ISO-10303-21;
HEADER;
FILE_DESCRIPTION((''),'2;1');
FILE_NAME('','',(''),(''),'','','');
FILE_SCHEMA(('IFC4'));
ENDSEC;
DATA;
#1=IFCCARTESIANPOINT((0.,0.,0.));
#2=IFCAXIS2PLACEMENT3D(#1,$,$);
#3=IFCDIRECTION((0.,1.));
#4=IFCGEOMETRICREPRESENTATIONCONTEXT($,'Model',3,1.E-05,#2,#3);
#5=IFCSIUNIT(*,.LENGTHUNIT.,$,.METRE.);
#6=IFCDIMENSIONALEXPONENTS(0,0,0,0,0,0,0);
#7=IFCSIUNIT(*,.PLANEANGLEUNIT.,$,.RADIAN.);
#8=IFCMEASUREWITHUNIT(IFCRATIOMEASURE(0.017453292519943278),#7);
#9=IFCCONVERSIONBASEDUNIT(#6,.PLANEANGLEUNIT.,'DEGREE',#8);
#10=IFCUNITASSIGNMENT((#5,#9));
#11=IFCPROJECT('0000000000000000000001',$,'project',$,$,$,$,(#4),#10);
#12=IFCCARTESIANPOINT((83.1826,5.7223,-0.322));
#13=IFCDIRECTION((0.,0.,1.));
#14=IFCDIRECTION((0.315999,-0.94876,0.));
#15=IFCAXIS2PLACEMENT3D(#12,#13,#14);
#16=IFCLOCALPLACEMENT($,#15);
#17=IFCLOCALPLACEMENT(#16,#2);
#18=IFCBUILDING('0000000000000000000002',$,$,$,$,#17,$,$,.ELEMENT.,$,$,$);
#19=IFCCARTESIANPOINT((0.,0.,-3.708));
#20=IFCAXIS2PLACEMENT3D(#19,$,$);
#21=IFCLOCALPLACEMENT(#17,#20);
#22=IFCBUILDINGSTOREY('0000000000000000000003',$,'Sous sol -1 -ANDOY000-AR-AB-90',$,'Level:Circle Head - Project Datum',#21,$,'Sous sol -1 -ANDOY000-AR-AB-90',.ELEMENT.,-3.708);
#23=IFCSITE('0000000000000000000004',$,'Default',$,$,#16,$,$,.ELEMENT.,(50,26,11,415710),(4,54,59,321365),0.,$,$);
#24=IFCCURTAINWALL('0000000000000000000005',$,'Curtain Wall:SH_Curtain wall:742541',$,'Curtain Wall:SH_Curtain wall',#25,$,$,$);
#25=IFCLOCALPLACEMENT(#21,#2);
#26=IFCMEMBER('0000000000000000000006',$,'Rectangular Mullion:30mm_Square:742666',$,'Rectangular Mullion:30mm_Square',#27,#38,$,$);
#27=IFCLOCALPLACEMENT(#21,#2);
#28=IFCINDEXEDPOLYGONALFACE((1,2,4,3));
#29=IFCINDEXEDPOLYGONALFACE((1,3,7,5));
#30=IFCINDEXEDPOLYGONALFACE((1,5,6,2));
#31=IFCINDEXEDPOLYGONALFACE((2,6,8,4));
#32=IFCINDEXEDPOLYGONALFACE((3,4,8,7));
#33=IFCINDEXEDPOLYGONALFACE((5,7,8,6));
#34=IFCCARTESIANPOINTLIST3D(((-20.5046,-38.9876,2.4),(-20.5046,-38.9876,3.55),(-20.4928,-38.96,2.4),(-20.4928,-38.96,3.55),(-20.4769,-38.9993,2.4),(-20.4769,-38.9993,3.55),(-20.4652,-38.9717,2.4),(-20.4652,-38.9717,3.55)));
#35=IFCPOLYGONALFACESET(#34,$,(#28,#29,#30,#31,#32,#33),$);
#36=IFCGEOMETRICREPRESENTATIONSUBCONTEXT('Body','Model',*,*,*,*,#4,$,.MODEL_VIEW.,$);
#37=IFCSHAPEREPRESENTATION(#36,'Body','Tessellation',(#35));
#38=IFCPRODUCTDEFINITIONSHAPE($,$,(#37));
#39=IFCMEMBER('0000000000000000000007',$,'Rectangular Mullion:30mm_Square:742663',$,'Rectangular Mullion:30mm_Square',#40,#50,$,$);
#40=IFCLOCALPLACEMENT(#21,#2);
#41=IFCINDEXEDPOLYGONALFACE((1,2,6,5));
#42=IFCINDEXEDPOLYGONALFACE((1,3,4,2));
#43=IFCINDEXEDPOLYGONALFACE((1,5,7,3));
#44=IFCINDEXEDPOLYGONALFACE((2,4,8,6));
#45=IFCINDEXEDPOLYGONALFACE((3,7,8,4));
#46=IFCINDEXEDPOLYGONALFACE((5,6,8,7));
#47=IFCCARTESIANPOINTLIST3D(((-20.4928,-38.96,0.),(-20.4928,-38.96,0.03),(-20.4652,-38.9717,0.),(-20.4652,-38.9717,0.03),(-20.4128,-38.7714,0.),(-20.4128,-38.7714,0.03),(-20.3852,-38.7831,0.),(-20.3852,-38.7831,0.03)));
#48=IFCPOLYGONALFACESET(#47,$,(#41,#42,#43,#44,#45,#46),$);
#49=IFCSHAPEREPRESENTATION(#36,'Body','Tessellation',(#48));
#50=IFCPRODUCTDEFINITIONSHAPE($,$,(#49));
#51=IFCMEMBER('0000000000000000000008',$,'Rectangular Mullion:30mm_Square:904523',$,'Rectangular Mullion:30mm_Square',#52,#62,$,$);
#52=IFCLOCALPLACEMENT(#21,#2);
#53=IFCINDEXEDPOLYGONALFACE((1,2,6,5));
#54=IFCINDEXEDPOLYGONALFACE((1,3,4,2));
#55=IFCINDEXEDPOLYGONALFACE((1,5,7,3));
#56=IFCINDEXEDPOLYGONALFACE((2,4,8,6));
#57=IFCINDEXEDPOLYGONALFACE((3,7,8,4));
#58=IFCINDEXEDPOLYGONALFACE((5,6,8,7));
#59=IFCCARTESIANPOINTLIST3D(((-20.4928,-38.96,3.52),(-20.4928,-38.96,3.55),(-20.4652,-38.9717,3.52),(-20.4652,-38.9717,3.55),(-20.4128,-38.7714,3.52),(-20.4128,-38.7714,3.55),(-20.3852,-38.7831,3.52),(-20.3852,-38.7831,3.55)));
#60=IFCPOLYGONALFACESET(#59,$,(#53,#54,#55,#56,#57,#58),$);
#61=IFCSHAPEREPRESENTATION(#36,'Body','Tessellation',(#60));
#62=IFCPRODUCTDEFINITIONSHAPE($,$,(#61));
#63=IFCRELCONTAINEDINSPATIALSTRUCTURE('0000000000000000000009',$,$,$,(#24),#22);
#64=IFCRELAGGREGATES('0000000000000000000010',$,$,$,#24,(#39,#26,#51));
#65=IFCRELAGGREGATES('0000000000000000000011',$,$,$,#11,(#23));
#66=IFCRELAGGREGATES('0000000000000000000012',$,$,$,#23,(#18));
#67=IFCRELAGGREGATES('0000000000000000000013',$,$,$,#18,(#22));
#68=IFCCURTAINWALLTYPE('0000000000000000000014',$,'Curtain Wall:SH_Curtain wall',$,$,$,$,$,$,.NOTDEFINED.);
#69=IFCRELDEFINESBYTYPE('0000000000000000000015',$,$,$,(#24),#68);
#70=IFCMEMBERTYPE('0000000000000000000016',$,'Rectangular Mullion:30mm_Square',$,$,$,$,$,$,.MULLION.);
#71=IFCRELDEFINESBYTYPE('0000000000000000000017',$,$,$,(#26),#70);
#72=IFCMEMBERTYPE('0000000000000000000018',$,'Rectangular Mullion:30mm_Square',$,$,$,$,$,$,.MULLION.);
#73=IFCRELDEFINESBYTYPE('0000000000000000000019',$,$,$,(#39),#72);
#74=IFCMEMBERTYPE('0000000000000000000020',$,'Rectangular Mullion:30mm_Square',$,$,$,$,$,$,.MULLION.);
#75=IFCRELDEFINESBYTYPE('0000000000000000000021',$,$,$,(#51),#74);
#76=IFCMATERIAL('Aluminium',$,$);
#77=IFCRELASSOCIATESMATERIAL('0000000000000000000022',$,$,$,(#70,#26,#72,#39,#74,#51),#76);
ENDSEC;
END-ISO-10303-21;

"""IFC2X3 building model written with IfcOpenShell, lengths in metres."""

from ifc_helpers import new_model, entity, si_unit, converted_unit, direction, frame, origin, origin_2d_with_axis, place, context, subcontext, project, spatial, rectangle, extrude, source, transform, mapped, material, type_object, type_shapes, element, aggregate, save


model = new_model("IFC2X3")

# Units and contexts
model_context = context("Model", 3, precision=1e-05, world=origin(), true_north=direction((0.0, 1.0)))
body_context = subcontext(model_context, "Body", "Model", "MODEL_VIEW")
ifc_project = project(units=[si_unit("LENGTHUNIT", "METRE"), converted_unit("PLANEANGLEUNIT", "DEGREE", entity("IfcRatioMeasure", 0.017453292519943278), si_unit("PLANEANGLEUNIT", "RADIAN"), dimensions=[0, 0, 0, 0, 0, 0, 0])], contexts=[model_context])

# Site, building, storey
site_placement = place(None, frame((83.1826, 5.7223, -0.322), z_axis=(0.0, 0.0, 1.0), x_axis=(0.315999, -0.94876, 0.0)))
site = spatial("IfcSite", under=ifc_project, at=site_placement, Name="Default", CompositionType="ELEMENT", RefLatitude=(50, 26, 11, 415710), RefLongitude=(4, 54, 59, 321365), RefElevation=0.0)
building_placement = place(site_placement, origin())
building = spatial("IfcBuilding", under=site, at=building_placement, CompositionType="ELEMENT")
storey_placement = place(building_placement, frame((0.0, 0.0, -3.708)))
storey = spatial("IfcBuildingStorey", under=building, at=storey_placement, Name="Sous sol -1 -ANDOY000-AR-AB-90", ObjectType="Level:Circle Head - Project Datum", LongName="Sous sol -1 -ANDOY000-AR-AB-90", CompositionType="ELEMENT", Elevation=-3.708)

# Curtain wall, members
curtain_wall_type = type_object("IfcCurtainWallType", Name="Curtain Wall:SH_Curtain wall", PredefinedType="NOTDEFINED")
curtain_wall_placement = place(storey_placement, frame((0.0, 0.0, 3.708)))
curtain_wall = element("IfcCurtainWall", 1, at=curtain_wall_placement, inside=storey, type_object=curtain_wall_type, Name="Curtain Wall:SH_Curtain wall:742541", ObjectType="Curtain Wall:SH_Curtain wall")
ifc_material_1 = material(Name="Aluminium")
member_type_1 = type_object("IfcMemberType", Name="Rectangular Mullion:30mm_Square", PredefinedType="MULLION", material=ifc_material_1)
shared_shape_1 = source(origin(), body_context, "Body", "SweptSolid", [
    extrude(rectangle(XDim=0.03, YDim=0.03, at=origin_2d_with_axis()), frame((0.0, 0.0, -1.15), z_axis=(0.0, 0.0, 1.0), x_axis=(0.0, -1.0, 0.0)), (0.0, 0.0, 1.0), 1.15),
])
type_shapes(member_type_1, [shared_shape_1])
member_1_placement = place(curtain_wall_placement, frame((-20.4849, -38.9796, -1.308), z_axis=(0.0, 0.0, -1.0), x_axis=(0.390731, 0.920505, 0.0)))
member_1 = element("IfcMember", 2, at=member_1_placement, type_object=member_type_1, material=ifc_material_1, Name="Rectangular Mullion:30mm_Square:742666", ObjectType="Rectangular Mullion:30mm_Square", context=body_context, shape_type="MappedRepresentation", body=[
    mapped(shared_shape_1, transform((0.0, 0.0, 0.0), scale=1.0)),
])
member_type_2 = type_object("IfcMemberType", Name="Rectangular Mullion:30mm_Square", PredefinedType="MULLION", material=ifc_material_1)
shared_shape_2 = source(origin(), body_context, "Body", "SweptSolid", [
    extrude(rectangle(XDim=0.03, YDim=0.03, at=origin_2d_with_axis()), frame((-0.015, 0.0, -0.2048), z_axis=(0.0, 0.0, 1.0), x_axis=(0.0, -1.0, 0.0)), (0.0, 0.0, 1.0), 0.2048),
])
type_shapes(member_type_2, [shared_shape_2])
member_2_placement = place(curtain_wall_placement, frame((-20.479, -38.9658, -3.708), z_axis=(-0.390731, -0.920505, 0.0), x_axis=(0.0, 0.0, -1.0)))
member_2 = element("IfcMember", 3, at=member_2_placement, type_object=member_type_2, material=ifc_material_1, Name="Rectangular Mullion:30mm_Square:742663", ObjectType="Rectangular Mullion:30mm_Square", context=body_context, shape_type="MappedRepresentation", body=[
    mapped(shared_shape_2, transform((0.0, 0.0, 0.0), scale=1.0)),
])
member_type_3 = type_object("IfcMemberType", Name="Rectangular Mullion:30mm_Square", PredefinedType="MULLION", material=ifc_material_1)
shared_shape_3 = source(origin(), body_context, "Body", "SweptSolid", [
    extrude(rectangle(XDim=0.03, YDim=0.03, at=origin_2d_with_axis()), frame((-0.015, 0.0, -0.2048), z_axis=(0.0, 0.0, 1.0), x_axis=(0.0, -1.0, 0.0)), (0.0, 0.0, 1.0), 0.2048),
])
type_shapes(member_type_3, [shared_shape_3])
member_3_placement = place(curtain_wall_placement, frame((-20.399, -38.7773, -0.158), z_axis=(0.390731, 0.920505, 0.0), x_axis=(0.0, 0.0, 1.0)))
member_3 = element("IfcMember", 4, at=member_3_placement, type_object=member_type_3, material=ifc_material_1, Name="Rectangular Mullion:30mm_Square:904523", ObjectType="Rectangular Mullion:30mm_Square", context=body_context, shape_type="MappedRepresentation", body=[
    mapped(shared_shape_3, transform((0.0, 0.0, 0.0), scale=1.0)),
])
aggregate(curtain_wall, [member_2, member_1, member_3])

save(model, "model.ifc")
